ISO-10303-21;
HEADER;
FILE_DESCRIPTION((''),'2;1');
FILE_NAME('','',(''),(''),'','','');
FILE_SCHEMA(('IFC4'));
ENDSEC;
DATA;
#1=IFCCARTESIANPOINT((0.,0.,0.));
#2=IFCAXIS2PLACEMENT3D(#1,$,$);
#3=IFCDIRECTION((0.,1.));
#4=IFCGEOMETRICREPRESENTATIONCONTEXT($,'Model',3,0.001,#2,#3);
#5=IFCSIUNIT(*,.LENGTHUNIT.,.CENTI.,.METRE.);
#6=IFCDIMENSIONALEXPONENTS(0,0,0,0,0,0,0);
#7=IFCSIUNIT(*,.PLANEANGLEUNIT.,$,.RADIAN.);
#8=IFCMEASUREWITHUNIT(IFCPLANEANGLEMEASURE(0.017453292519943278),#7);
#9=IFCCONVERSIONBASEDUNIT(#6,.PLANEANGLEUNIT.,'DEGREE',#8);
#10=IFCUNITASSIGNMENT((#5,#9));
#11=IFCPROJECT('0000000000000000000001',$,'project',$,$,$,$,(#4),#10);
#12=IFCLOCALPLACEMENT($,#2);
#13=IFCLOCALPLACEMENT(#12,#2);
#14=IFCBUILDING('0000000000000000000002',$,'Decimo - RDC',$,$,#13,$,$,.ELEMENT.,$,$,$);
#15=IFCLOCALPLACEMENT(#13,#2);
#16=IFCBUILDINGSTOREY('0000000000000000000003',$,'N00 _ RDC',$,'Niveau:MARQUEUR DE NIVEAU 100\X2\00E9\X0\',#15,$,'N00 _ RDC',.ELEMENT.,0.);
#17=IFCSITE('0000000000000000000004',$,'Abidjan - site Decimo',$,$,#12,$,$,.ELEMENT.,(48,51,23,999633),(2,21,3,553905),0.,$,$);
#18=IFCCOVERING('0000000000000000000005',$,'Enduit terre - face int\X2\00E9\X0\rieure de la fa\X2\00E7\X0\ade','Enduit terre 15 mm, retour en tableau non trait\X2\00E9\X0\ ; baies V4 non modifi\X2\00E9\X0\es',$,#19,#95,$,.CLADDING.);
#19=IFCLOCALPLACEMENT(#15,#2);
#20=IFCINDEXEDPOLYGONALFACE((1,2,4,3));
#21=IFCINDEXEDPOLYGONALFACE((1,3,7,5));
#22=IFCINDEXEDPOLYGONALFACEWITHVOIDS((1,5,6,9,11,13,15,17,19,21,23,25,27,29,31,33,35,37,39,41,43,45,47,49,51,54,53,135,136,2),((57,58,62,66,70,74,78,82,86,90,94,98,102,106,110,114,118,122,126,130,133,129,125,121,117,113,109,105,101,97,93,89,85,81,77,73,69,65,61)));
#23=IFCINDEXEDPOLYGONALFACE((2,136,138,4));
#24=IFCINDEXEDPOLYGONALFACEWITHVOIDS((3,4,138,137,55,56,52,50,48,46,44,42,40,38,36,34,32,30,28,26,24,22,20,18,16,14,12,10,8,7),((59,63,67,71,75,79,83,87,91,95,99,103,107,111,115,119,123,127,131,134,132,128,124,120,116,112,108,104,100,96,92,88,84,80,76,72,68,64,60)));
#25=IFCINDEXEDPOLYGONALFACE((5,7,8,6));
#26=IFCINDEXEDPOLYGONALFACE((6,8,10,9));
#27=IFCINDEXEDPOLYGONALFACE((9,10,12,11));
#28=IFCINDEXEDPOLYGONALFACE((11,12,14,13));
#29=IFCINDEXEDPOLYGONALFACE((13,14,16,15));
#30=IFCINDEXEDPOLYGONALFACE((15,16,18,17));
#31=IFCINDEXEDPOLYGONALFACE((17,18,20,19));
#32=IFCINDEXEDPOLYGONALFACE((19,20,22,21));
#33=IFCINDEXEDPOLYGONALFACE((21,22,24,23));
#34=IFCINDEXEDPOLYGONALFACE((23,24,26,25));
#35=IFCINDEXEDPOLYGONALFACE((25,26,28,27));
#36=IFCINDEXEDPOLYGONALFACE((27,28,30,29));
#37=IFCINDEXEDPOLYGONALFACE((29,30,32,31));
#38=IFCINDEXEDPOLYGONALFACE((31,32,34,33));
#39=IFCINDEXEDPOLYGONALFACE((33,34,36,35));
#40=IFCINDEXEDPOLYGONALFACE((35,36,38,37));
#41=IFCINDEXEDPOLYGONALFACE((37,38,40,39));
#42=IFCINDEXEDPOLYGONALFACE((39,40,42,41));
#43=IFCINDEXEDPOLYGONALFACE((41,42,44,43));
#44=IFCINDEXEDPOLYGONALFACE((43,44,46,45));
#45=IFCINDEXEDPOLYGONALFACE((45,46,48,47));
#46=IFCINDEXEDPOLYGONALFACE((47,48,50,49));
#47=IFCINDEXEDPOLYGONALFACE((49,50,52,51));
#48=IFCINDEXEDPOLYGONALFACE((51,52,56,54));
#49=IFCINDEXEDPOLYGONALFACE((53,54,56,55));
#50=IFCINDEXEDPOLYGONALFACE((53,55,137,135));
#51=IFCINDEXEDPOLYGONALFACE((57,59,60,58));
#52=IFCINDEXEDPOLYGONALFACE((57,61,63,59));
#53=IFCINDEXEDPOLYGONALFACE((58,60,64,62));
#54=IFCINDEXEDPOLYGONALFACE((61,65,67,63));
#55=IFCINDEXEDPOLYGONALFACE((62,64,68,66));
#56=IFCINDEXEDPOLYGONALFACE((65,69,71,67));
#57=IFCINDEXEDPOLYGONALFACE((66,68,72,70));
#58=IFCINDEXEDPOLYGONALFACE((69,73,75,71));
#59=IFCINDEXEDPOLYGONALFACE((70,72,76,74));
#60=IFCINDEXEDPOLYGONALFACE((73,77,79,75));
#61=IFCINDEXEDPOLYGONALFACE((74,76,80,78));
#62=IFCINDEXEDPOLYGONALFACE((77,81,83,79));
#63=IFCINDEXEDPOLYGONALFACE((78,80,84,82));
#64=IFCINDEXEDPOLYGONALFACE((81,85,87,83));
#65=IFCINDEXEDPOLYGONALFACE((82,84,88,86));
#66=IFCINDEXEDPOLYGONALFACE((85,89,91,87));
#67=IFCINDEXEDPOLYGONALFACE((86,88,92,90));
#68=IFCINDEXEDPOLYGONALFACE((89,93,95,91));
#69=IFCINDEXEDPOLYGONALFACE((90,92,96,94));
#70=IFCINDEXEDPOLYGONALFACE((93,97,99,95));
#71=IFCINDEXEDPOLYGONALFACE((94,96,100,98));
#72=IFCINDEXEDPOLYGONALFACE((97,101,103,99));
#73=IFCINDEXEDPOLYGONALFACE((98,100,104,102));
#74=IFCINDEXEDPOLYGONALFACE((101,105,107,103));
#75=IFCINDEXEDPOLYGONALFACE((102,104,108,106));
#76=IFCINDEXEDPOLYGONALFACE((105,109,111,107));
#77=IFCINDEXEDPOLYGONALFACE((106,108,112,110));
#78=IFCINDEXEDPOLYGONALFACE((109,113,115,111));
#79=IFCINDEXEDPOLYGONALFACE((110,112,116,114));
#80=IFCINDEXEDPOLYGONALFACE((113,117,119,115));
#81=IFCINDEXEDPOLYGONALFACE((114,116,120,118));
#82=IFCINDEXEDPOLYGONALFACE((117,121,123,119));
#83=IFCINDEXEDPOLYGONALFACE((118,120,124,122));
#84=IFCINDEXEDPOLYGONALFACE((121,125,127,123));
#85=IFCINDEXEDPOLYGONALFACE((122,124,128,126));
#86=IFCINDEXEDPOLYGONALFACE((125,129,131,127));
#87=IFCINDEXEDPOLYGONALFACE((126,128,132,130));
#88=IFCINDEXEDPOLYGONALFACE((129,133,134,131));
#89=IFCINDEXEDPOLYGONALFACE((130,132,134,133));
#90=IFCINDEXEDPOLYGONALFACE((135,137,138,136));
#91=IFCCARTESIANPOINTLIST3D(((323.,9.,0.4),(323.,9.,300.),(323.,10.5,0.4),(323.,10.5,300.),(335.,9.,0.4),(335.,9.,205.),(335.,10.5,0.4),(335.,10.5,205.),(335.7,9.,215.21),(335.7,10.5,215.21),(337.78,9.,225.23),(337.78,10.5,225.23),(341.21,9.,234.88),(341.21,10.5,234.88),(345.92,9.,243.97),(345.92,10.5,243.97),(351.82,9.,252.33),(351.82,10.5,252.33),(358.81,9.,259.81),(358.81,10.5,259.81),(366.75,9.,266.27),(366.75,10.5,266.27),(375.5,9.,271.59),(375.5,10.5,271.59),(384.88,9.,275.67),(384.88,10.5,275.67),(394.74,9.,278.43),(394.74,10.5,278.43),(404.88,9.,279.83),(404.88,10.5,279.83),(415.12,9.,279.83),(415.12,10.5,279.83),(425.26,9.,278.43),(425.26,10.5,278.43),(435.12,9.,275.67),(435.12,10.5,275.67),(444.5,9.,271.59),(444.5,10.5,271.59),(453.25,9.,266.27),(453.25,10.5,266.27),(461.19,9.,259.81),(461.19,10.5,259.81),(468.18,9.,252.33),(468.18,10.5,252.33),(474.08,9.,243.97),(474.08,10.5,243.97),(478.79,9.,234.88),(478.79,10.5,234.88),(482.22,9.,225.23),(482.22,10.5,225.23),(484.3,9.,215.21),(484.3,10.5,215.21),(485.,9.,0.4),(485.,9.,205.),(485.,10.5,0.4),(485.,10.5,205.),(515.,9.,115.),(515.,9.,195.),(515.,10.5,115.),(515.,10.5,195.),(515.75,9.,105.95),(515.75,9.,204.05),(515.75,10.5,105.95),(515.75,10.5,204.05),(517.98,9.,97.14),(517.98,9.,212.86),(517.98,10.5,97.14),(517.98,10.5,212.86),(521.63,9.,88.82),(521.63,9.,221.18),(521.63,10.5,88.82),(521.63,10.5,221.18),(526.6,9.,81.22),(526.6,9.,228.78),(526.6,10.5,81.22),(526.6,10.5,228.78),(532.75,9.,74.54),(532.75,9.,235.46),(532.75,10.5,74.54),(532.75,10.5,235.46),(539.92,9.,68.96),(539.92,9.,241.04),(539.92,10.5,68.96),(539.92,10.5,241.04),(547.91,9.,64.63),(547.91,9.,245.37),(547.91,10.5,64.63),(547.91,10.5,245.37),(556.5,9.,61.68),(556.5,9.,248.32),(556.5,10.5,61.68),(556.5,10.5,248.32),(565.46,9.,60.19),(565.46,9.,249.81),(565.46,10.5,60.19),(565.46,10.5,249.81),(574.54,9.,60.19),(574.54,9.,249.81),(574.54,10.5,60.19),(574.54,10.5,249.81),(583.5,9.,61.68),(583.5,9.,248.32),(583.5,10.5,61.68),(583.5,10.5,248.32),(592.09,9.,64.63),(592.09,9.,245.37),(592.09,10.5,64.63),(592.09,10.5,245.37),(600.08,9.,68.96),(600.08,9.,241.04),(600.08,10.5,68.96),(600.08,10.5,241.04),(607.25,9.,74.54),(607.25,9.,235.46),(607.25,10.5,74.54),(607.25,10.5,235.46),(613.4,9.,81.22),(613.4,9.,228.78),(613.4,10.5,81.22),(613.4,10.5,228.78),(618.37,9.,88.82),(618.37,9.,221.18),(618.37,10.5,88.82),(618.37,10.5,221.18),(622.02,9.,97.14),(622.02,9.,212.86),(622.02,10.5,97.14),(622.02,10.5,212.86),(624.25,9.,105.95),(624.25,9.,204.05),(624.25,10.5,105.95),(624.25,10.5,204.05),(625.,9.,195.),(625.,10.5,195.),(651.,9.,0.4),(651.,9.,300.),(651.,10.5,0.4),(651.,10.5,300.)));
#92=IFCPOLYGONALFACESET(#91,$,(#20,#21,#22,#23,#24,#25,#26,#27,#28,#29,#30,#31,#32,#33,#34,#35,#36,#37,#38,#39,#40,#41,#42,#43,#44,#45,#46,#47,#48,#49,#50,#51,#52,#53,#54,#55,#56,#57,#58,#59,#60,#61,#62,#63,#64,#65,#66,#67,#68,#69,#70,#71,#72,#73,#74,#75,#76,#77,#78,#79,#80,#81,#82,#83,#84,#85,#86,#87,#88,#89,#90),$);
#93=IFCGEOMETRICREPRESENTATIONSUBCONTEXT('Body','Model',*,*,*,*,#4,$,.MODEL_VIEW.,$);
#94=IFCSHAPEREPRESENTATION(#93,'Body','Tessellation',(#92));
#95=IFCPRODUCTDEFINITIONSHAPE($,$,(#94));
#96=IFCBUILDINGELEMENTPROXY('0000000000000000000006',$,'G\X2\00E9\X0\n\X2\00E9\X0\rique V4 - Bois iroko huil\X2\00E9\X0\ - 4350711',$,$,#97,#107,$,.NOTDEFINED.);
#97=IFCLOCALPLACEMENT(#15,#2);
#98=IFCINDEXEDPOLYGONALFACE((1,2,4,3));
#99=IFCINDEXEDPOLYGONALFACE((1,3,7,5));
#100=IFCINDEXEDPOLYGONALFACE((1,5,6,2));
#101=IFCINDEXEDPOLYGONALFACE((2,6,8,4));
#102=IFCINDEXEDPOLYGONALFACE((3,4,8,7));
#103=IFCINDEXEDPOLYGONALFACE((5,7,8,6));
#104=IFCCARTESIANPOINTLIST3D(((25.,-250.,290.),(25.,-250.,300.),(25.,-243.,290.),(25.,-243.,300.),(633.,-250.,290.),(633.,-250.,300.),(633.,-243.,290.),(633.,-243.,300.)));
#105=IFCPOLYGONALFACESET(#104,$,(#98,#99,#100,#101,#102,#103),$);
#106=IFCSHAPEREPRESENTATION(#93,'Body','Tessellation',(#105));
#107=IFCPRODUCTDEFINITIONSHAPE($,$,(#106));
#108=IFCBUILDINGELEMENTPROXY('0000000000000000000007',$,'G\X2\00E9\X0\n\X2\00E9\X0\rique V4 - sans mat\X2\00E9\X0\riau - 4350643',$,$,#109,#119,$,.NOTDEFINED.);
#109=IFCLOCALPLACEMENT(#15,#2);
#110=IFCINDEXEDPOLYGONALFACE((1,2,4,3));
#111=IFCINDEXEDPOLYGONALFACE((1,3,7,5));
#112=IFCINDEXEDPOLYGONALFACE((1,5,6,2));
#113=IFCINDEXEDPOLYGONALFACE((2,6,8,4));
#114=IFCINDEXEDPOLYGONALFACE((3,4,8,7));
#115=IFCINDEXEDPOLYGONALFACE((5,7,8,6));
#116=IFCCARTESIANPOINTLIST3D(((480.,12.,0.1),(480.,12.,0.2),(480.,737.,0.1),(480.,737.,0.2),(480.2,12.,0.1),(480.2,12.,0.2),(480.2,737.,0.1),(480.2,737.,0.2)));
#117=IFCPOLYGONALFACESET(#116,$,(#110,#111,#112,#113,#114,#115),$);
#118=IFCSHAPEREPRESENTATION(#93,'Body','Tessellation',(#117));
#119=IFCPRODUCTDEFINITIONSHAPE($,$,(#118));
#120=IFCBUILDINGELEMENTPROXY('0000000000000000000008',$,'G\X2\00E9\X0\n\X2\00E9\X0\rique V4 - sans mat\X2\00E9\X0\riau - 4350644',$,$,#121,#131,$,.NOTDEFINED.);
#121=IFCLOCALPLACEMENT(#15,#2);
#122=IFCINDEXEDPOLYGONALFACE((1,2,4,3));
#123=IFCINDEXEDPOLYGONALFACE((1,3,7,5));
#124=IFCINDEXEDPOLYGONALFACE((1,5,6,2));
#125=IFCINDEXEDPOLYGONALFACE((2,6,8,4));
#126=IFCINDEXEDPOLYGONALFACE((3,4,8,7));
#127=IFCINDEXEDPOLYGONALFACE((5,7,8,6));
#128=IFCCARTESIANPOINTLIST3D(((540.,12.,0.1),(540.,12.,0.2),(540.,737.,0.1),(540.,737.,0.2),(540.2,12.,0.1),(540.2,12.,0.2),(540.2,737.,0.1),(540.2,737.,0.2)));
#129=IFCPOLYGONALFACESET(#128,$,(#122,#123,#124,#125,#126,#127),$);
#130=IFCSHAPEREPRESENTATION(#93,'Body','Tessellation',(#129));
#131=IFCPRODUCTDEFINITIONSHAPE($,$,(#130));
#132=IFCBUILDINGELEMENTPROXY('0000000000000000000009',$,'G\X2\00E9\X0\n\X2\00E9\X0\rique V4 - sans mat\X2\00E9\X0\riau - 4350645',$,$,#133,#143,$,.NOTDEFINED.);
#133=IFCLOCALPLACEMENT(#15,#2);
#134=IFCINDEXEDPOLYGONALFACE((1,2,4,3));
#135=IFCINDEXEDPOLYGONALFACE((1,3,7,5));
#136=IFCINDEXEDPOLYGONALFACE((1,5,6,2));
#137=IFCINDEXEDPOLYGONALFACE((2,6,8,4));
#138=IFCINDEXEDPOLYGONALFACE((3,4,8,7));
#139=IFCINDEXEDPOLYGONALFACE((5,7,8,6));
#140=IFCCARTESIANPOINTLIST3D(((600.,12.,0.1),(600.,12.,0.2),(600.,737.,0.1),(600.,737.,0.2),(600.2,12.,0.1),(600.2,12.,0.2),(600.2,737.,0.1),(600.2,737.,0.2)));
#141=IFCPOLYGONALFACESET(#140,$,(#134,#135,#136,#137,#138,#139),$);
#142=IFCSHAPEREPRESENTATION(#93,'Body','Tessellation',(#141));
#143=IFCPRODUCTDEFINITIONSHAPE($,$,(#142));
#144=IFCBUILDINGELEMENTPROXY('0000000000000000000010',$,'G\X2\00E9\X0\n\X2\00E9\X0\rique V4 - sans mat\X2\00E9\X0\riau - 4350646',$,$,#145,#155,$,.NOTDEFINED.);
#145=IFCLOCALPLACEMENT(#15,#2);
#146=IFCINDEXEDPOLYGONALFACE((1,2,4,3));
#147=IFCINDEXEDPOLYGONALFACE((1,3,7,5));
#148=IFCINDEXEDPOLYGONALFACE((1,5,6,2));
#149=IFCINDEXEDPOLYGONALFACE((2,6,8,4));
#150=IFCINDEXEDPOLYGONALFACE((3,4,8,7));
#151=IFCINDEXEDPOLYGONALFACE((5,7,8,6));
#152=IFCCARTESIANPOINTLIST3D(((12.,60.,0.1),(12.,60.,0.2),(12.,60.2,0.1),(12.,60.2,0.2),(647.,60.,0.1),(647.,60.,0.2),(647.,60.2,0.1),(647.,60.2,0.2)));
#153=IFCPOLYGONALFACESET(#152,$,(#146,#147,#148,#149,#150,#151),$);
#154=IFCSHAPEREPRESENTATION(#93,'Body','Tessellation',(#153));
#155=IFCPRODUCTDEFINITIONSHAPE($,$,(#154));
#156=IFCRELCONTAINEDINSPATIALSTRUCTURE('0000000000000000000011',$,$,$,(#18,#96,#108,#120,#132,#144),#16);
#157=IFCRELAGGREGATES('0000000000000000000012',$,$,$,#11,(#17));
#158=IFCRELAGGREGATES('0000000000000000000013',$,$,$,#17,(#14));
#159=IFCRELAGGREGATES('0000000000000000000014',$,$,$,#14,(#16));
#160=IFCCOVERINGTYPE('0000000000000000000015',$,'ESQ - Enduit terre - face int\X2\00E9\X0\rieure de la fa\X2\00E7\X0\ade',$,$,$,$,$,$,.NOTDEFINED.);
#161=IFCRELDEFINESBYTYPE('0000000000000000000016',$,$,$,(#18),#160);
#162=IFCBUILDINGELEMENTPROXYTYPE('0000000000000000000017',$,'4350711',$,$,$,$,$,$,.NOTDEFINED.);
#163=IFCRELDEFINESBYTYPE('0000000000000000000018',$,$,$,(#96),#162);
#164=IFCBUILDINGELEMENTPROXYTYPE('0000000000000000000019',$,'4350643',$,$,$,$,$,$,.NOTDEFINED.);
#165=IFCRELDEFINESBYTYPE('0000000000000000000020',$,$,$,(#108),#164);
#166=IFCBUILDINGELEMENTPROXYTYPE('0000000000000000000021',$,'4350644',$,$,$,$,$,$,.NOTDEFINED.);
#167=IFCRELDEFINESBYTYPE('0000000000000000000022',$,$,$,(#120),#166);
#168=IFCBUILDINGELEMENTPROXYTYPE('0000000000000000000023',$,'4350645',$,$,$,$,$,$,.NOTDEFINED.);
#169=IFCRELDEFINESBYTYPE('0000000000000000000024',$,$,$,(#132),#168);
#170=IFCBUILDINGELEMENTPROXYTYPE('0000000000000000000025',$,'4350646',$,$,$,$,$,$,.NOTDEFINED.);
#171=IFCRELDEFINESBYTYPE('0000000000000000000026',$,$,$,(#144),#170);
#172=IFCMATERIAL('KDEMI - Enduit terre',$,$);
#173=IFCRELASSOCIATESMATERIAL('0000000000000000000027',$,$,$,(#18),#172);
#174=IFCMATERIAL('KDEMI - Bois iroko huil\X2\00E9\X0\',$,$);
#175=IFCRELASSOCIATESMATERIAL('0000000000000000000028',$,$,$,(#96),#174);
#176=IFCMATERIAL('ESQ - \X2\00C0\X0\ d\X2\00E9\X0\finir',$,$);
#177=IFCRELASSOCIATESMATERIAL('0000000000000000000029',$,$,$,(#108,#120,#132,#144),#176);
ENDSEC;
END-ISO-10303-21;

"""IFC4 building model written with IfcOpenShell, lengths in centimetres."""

from ifc_helpers import new_model, entity, si_unit, converted_unit, direction, frame, frame_2d, origin, origin_with_axes, origin_2d_with_axis, place, context, subcontext, project, spatial, polyline, rectangle, outline, extrude, material, type_object, element, save


model = new_model("IFC4")

# Units and contexts
model_context = context("Model", 3, precision=0.001, world=origin(), true_north=direction((0.0, 1.0)))
body_context = subcontext(model_context, "Body", "Model", "MODEL_VIEW")
ifc_project = project(units=[si_unit("LENGTHUNIT", "METRE", prefix="CENTI"), converted_unit("PLANEANGLEUNIT", "DEGREE", entity("IfcPlaneAngleMeasure", 0.017453292519943278), si_unit("PLANEANGLEUNIT", "RADIAN"), dimensions=[0, 0, 0, 0, 0, 0, 0])], contexts=[model_context])

# Site, building, storey
site_placement = place(None, origin())
site = spatial("IfcSite", under=ifc_project, at=site_placement, Name="Abidjan - site Decimo", CompositionType="ELEMENT", RefLatitude=(48, 51, 23, 999633), RefLongitude=(2, 21, 3, 553905), RefElevation=0.0)
building_placement = place(site_placement, origin())
building = spatial("IfcBuilding", under=site, at=building_placement, Name="Decimo - RDC", CompositionType="ELEMENT")
storey_placement = place(building_placement, origin())
storey = spatial("IfcBuildingStorey", under=building, at=storey_placement, Name="N00 _ RDC", ObjectType="Niveau:MARQUEUR DE NIVEAU 100é", LongName="N00 _ RDC", CompositionType="ELEMENT", Elevation=0.0)

# Shared definitions
ifc_material_1 = material(Name="KDEMI - Bois iroko huilé")

# Covering
ifc_material_2 = material(Name="KDEMI - Enduit terre")
covering_type_1 = type_object("IfcCoveringType", Name="ESQ - Enduit terre - face intérieure de la façade", PredefinedType="NOTDEFINED")
covering_1_placement = place(storey_placement, origin_with_axes())
element("IfcCovering", 1, at=covering_1_placement, inside=storey, type_object=covering_type_1, material=ifc_material_2, Name="Enduit terre - face intérieure de la façade", Description="Enduit terre 15 mm, retour en tableau non traité ; baies V4 non modifiées", PredefinedType="CLADDING", context=body_context, shape_type="SweptSolid", body=[
    extrude(outline(polyline([(323.0, 300.0), (651.0, 300.0), (651.0, 0.4), (485.0, 0.4), (485.0, 205.0), (484.3, 215.21), (482.22, 225.23), (478.79, 234.88), (474.08, 243.97), (468.18, 252.33), (461.19, 259.81), (453.25, 266.27), (444.5, 271.59), (435.12, 275.67), (425.26, 278.43), (415.12, 279.83), (404.88, 279.83), (394.74, 278.43), (384.88, 275.67), (375.5, 271.59), (366.75, 266.27), (358.81, 259.81), (351.82, 252.33), (345.92, 243.97), (341.21, 234.88), (337.78, 225.23), (335.7, 215.21), (335.0, 205.0), (335.0, 0.4), (323.0, 0.4), (323.0, 300.0)]), holes=[polyline([(624.25, 204.05), (622.02, 212.86), (618.37, 221.18), (613.4, 228.78), (607.25, 235.46), (600.08, 241.04), (592.09, 245.37), (583.5, 248.32), (574.54, 249.81), (565.46, 249.81), (556.5, 248.32), (547.91, 245.37), (539.92, 241.04), (532.75, 235.46), (526.6, 228.78), (521.63, 221.18), (517.98, 212.86), (515.75, 204.05), (515.0, 195.0), (515.0, 115.0), (515.75, 105.95), (517.98, 97.14), (521.63, 88.82), (526.6, 81.22), (532.75, 74.54), (539.92, 68.96), (547.91, 64.63), (556.5, 61.68), (565.46, 60.19), (574.54, 60.19), (583.5, 61.68), (592.09, 64.63), (600.08, 68.96), (607.25, 74.54), (613.4, 81.22), (618.37, 88.82), (622.02, 97.14), (624.25, 105.95), (625.0, 195.0), (624.25, 204.05)])]), frame((0.0, 10.5, 0.0), z_axis=(0.0, -1.0, 0.0), x_axis=(1.0, 0.0, 0.0)), (0.0, 0.0, 1.0), 1.5),
])

# Building element proxies
building_element_proxy_type_1 = type_object("IfcBuildingElementProxyType", Name="4350711", PredefinedType="NOTDEFINED")
proxy_1_placement = place(storey_placement, frame((0.0, 0.0, 25.0), z_axis=(0.0, 0.0, 1.0), x_axis=(1.0, 0.0, 0.0)))
element("IfcBuildingElementProxy", 2, at=proxy_1_placement, inside=storey, type_object=building_element_proxy_type_1, material=ifc_material_1, Name="Générique V4 - Bois iroko huilé - 4350711", PredefinedType="NOTDEFINED", context=body_context, shape_type="SweptSolid", body=[
    extrude(rectangle(XDim=608.0, YDim=7.0, at=frame_2d((0.0, 0.0), x_axis=(1.0, 0.0))), frame((329.0, -246.5, 265.0)), (0.0, 0.0, 1.0), 10.0),
])
ifc_material_3 = material(Name="ESQ - À définir")
building_element_proxy_type_2 = type_object("IfcBuildingElementProxyType", Name="4350643", PredefinedType="NOTDEFINED")
proxy_2_placement = place(storey_placement, origin())
element("IfcBuildingElementProxy", 3, at=proxy_2_placement, inside=storey, type_object=building_element_proxy_type_2, material=ifc_material_3, Name="Générique V4 - sans matériau - 4350643", PredefinedType="NOTDEFINED", context=body_context, shape_type="SweptSolid", body=[
    extrude(rectangle(XDim=0.2, YDim=725.0, at=origin_2d_with_axis()), frame((480.1, 374.5, 0.1)), (0.0, 0.0, 1.0), 0.1),
])
building_element_proxy_type_3 = type_object("IfcBuildingElementProxyType", Name="4350644", PredefinedType="NOTDEFINED")
proxy_3_placement = place(storey_placement, origin())
element("IfcBuildingElementProxy", 4, at=proxy_3_placement, inside=storey, type_object=building_element_proxy_type_3, material=ifc_material_3, Name="Générique V4 - sans matériau - 4350644", PredefinedType="NOTDEFINED", context=body_context, shape_type="SweptSolid", body=[
    extrude(rectangle(XDim=0.2, YDim=725.0, at=origin_2d_with_axis()), frame((540.1, 374.5, 0.1)), (0.0, 0.0, 1.0), 0.1),
])
building_element_proxy_type_4 = type_object("IfcBuildingElementProxyType", Name="4350645", PredefinedType="NOTDEFINED")
proxy_4_placement = place(storey_placement, origin())
element("IfcBuildingElementProxy", 5, at=proxy_4_placement, inside=storey, type_object=building_element_proxy_type_4, material=ifc_material_3, Name="Générique V4 - sans matériau - 4350645", PredefinedType="NOTDEFINED", context=body_context, shape_type="SweptSolid", body=[
    extrude(rectangle(XDim=0.2, YDim=725.0, at=origin_2d_with_axis()), frame((600.1, 374.5, 0.1)), (0.0, 0.0, 1.0), 0.1),
])
building_element_proxy_type_5 = type_object("IfcBuildingElementProxyType", Name="4350646", PredefinedType="NOTDEFINED")
proxy_5_placement = place(storey_placement, origin())
element("IfcBuildingElementProxy", 6, at=proxy_5_placement, inside=storey, type_object=building_element_proxy_type_5, material=ifc_material_3, Name="Générique V4 - sans matériau - 4350646", PredefinedType="NOTDEFINED", context=body_context, shape_type="SweptSolid", body=[
    extrude(rectangle(XDim=635.0, YDim=0.2, at=frame_2d((0.0, 0.0), x_axis=(1.0, 0.0))), frame((329.5, 60.1, 0.1)), (0.0, 0.0, 1.0), 0.1),
])

save(model, "model.ifc")
